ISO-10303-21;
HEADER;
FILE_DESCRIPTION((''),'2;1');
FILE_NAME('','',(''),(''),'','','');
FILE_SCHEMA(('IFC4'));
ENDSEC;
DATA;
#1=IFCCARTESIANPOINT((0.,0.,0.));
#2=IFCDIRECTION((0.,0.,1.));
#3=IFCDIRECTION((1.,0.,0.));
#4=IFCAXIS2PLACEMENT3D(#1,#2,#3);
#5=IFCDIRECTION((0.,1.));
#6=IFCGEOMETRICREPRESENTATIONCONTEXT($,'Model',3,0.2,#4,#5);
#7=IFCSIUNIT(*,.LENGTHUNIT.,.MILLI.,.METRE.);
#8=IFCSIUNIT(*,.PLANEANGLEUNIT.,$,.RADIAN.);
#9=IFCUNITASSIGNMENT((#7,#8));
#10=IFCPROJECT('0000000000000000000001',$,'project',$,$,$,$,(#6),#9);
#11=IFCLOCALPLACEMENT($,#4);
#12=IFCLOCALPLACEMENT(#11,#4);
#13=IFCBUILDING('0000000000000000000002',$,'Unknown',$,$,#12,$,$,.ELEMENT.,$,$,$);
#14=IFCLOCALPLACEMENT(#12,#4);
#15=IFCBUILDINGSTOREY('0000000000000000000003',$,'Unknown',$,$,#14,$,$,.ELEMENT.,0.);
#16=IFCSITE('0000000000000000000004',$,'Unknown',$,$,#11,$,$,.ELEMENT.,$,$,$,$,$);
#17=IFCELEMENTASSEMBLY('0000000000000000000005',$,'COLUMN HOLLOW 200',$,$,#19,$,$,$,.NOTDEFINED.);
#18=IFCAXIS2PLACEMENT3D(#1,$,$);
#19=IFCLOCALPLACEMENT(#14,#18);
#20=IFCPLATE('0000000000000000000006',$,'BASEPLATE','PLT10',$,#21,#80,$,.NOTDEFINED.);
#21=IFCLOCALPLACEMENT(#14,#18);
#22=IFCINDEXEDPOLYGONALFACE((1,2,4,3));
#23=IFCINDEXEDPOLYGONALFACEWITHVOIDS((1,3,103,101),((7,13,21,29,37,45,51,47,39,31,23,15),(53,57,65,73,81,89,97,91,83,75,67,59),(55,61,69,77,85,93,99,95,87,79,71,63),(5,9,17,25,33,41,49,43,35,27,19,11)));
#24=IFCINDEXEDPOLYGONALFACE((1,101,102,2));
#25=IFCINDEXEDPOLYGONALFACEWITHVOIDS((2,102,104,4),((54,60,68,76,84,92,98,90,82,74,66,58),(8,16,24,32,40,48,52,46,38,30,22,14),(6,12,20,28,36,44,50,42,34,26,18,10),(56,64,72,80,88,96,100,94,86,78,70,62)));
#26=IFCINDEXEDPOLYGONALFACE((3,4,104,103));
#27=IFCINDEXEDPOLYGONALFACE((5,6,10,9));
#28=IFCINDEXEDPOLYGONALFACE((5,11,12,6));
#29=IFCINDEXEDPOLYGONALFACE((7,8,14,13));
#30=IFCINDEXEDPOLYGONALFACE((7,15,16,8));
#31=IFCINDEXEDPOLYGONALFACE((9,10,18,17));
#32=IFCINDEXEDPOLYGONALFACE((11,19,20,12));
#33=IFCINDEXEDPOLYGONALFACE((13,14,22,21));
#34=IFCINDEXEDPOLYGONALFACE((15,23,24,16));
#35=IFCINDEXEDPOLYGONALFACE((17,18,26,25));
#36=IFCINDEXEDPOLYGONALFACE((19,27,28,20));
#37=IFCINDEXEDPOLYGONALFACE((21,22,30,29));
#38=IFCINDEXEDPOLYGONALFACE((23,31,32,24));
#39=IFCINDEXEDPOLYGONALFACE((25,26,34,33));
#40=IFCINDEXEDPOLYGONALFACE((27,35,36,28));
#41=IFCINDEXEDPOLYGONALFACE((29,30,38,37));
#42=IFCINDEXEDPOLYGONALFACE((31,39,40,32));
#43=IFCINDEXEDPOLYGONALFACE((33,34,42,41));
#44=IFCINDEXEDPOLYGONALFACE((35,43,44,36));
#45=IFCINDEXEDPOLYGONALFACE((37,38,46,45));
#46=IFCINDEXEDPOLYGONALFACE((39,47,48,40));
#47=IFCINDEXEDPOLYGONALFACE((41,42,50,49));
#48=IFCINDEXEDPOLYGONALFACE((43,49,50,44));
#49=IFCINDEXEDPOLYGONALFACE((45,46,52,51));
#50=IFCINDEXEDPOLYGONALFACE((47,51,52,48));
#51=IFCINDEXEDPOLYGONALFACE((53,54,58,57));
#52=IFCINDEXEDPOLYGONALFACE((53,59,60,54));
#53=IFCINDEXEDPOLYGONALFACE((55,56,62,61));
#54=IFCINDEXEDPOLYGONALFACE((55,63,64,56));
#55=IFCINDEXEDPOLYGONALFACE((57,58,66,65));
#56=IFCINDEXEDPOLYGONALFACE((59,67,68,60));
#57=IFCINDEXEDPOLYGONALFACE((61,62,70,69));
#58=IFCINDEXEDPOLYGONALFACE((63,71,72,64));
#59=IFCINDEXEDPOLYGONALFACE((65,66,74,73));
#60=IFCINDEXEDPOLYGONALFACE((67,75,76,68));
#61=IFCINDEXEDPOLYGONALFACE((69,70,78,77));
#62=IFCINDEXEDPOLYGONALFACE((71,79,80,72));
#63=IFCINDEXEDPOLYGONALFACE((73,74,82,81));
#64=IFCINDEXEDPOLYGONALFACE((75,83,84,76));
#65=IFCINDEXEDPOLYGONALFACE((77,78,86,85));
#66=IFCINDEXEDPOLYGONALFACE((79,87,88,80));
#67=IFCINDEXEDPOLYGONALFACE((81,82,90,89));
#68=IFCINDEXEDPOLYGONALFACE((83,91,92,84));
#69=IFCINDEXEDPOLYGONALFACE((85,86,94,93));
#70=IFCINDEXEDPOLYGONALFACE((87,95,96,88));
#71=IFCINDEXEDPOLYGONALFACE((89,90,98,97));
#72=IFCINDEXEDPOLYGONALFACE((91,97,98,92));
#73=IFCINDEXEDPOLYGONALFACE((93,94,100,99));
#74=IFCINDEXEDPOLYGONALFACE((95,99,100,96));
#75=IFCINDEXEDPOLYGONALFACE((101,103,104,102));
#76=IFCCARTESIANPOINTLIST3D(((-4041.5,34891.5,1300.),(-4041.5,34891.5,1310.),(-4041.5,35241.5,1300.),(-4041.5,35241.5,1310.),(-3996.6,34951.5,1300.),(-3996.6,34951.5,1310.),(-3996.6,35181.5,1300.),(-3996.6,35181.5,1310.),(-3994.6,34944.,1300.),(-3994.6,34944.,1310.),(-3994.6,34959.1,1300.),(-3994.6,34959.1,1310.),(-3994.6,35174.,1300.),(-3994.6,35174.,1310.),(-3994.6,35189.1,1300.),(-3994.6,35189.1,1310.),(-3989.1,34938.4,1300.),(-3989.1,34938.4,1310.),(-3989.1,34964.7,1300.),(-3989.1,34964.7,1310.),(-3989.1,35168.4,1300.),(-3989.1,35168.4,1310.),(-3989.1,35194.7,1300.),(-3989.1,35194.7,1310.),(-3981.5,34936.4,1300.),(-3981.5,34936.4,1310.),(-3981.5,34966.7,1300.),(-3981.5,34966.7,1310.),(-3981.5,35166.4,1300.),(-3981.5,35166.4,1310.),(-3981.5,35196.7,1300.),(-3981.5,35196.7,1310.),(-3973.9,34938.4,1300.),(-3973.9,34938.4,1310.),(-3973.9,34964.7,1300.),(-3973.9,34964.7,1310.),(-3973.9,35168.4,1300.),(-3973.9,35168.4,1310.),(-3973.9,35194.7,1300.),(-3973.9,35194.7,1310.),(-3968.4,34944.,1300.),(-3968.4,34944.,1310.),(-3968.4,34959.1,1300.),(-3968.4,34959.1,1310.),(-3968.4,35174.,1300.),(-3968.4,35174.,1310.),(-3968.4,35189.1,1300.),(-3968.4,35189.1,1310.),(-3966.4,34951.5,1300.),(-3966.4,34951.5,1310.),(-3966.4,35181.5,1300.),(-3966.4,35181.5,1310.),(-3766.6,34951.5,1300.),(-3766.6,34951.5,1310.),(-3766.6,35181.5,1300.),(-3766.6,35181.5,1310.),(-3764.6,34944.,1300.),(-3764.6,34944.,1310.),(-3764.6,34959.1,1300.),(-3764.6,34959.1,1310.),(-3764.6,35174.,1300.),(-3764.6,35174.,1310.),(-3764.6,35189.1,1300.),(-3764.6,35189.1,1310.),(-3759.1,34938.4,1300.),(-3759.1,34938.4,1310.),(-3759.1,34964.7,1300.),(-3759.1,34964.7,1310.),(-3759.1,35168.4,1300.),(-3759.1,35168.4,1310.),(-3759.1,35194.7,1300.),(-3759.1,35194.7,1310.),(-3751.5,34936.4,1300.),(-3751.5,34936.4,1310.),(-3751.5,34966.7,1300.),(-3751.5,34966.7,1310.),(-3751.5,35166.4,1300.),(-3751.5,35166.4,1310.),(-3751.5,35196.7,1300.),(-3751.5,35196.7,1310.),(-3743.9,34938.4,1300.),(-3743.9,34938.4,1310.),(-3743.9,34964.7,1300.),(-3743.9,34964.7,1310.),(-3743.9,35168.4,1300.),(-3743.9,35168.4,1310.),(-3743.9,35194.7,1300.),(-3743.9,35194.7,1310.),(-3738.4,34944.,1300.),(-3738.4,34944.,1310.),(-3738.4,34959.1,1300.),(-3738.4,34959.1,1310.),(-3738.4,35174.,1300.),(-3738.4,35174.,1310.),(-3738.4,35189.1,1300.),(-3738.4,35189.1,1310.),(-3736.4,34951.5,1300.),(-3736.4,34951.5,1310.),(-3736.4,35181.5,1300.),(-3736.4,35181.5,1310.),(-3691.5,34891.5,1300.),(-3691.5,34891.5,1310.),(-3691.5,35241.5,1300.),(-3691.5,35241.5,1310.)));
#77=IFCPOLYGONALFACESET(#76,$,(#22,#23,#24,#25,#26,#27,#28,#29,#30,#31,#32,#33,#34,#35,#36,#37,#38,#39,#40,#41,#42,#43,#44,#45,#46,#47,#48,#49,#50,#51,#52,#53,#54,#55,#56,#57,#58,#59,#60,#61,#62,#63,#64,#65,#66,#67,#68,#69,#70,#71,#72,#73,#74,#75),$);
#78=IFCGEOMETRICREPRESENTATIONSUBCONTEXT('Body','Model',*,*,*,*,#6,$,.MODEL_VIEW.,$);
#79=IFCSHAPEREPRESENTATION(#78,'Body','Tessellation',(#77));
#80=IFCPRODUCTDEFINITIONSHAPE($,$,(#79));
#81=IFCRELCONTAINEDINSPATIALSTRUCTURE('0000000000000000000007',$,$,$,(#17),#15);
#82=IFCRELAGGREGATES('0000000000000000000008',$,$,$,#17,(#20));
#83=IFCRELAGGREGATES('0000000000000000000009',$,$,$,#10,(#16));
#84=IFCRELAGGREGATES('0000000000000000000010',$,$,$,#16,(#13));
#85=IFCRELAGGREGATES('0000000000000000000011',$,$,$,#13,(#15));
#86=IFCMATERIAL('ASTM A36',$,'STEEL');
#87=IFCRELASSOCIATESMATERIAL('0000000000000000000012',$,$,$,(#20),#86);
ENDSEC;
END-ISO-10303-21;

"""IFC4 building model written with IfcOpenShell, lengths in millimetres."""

from ifc_helpers import new_model, si_unit, direction, frame, origin_with_axes, place, context, subcontext, project, spatial, line, indexed_curve, outline, extrude, material, element, aggregate, save


model = new_model("IFC4")

# Units and contexts
model_context = context("Model", 3, precision=0.2, world=origin_with_axes(), true_north=direction((0.0, 1.0)))
body_context = subcontext(model_context, "Body", "Model", "MODEL_VIEW")
ifc_project = project(units=[si_unit("LENGTHUNIT", "METRE", prefix="MILLI"), si_unit("PLANEANGLEUNIT", "RADIAN")], contexts=[model_context])

# Site, building, storey
site_placement = place(None, origin_with_axes())
site = spatial("IfcSite", under=ifc_project, at=site_placement, Name="Unknown", CompositionType="ELEMENT")
building_placement = place(site_placement, origin_with_axes())
building = spatial("IfcBuilding", under=site, at=building_placement, Name="Unknown", CompositionType="ELEMENT")
storey_placement = place(building_placement, origin_with_axes())
storey = spatial("IfcBuildingStorey", under=building, at=storey_placement, Name="Unknown", CompositionType="ELEMENT", Elevation=0.0)

# Shared definitions
ifc_material_1 = material(Name="ASTM A36", Category="STEEL")

# Element assembly, plate, voiding features
assembly_1_placement = place(storey_placement, frame((-3879.7, 35066.5, 1158.6), z_axis=(0.0, -1.0, 0.0), x_axis=(0.087156, 0.0, 0.996195)))
assembly_1 = element("IfcElementAssembly", 1, at=assembly_1_placement, inside=storey, Name="COLUMN HOLLOW 200", PredefinedType="NOTDEFINED")
plate_1_placement = place(assembly_1_placement, frame((131.8, 173.9, 175.0), z_axis=(-0.996195, -0.087156, 0.0), x_axis=(0.0, 0.0, -1.0)))
plate_1 = element("IfcPlate", 2, at=plate_1_placement, material=ifc_material_1, Name="BASEPLATE", Description="PLT10", PredefinedType="NOTDEFINED", context=body_context, shape_type="SolidModel", body=[
    extrude(outline(indexed_curve([(0.0, 0.0), (350.0, 0.0), (350.0, 350.0), (0.0, 350.0)], segments=[line(1, 2, 3, 4, 1)])), frame((0.0, 0.0, 5.0), z_axis=(0.0, 0.0, 1.0), x_axis=(1.0, 0.0, 0.0)), (0.0, 0.0, -1.0), 10.0),
])
voiding_feature_1_placement = place(plate_1_placement, frame((290.0, 60.0, 5.5), z_axis=(-1.0, 0.0, 0.0), x_axis=(0.0, 0.0, -1.0)))
element("IfcVoidingFeature", 3, at=voiding_feature_1_placement, cuts=plate_1, Name="BEAM", PredefinedType="HOLE", context=body_context, shape_type="SolidModel", body=[
    extrude(outline(indexed_curve([(15.1, 0.0), (13.1, 7.6), (7.6, 13.1), (0.0, 15.1), (-7.6, 13.1), (-13.1, 7.6), (-15.1, 0.0), (-13.1, -7.6), (-7.6, -13.1), (0.0, -15.1), (7.6, -13.1), (13.1, -7.6)], segments=[line(1, 2, 3, 4, 5, 6, 7, 8, 9, 10, 11, 12, 1)])), frame((0.0, 0.0, 0.0), z_axis=(-1.0, 0.0, 0.0), x_axis=(0.0, 0.0, 1.0)), (0.0, 0.0, -1.0), 11.0),
])
voiding_feature_2_placement = place(plate_1_placement, frame((60.0, 60.0, 5.5), z_axis=(-1.0, 0.0, 0.0), x_axis=(0.0, 0.0, -1.0)))
element("IfcVoidingFeature", 4, at=voiding_feature_2_placement, cuts=plate_1, Name="BEAM", PredefinedType="HOLE", context=body_context, shape_type="SolidModel", body=[
    extrude(outline(indexed_curve([(15.1, 0.0), (13.1, 7.6), (7.6, 13.1), (0.0, 15.1), (-7.6, 13.1), (-13.1, 7.6), (-15.1, 0.0), (-13.1, -7.6), (-7.6, -13.1), (0.0, -15.1), (7.6, -13.1), (13.1, -7.6)], segments=[line(1, 2, 3, 4, 5, 6, 7, 8, 9, 10, 11, 12, 1)])), frame((0.0, 0.0, 0.0), z_axis=(-1.0, 0.0, 0.0), x_axis=(0.0, 0.0, 1.0)), (0.0, 0.0, -1.0), 11.0),
])
voiding_feature_3_placement = place(plate_1_placement, frame((290.0, 290.0, 5.5), z_axis=(-1.0, 0.0, 0.0), x_axis=(0.0, 0.0, -1.0)))
element("IfcVoidingFeature", 5, at=voiding_feature_3_placement, cuts=plate_1, Name="BEAM", PredefinedType="HOLE", context=body_context, shape_type="SolidModel", body=[
    extrude(outline(indexed_curve([(15.1, 0.0), (13.1, 7.6), (7.6, 13.1), (0.0, 15.1), (-7.6, 13.1), (-13.1, 7.6), (-15.1, 0.0), (-13.1, -7.6), (-7.6, -13.1), (0.0, -15.1), (7.6, -13.1), (13.1, -7.6)], segments=[line(1, 2, 3, 4, 5, 6, 7, 8, 9, 10, 11, 12, 1)])), frame((0.0, 0.0, 0.0), z_axis=(-1.0, 0.0, 0.0), x_axis=(0.0, 0.0, 1.0)), (0.0, 0.0, -1.0), 11.0),
])
voiding_feature_4_placement = place(plate_1_placement, frame((60.0, 290.0, 5.5), z_axis=(-1.0, 0.0, 0.0), x_axis=(0.0, 0.0, -1.0)))
element("IfcVoidingFeature", 6, at=voiding_feature_4_placement, cuts=plate_1, Name="BEAM", PredefinedType="HOLE", context=body_context, shape_type="SolidModel", body=[
    extrude(outline(indexed_curve([(15.1, 0.0), (13.1, 7.6), (7.6, 13.1), (0.0, 15.1), (-7.6, 13.1), (-13.1, 7.6), (-15.1, 0.0), (-13.1, -7.6), (-7.6, -13.1), (0.0, -15.1), (7.6, -13.1), (13.1, -7.6)], segments=[line(1, 2, 3, 4, 5, 6, 7, 8, 9, 10, 11, 12, 1)])), frame((0.0, 0.0, 0.0), z_axis=(-1.0, 0.0, 0.0), x_axis=(0.0, 0.0, 1.0)), (0.0, 0.0, -1.0), 11.0),
])
aggregate(assembly_1, [plate_1])

save(model, "model.ifc")
